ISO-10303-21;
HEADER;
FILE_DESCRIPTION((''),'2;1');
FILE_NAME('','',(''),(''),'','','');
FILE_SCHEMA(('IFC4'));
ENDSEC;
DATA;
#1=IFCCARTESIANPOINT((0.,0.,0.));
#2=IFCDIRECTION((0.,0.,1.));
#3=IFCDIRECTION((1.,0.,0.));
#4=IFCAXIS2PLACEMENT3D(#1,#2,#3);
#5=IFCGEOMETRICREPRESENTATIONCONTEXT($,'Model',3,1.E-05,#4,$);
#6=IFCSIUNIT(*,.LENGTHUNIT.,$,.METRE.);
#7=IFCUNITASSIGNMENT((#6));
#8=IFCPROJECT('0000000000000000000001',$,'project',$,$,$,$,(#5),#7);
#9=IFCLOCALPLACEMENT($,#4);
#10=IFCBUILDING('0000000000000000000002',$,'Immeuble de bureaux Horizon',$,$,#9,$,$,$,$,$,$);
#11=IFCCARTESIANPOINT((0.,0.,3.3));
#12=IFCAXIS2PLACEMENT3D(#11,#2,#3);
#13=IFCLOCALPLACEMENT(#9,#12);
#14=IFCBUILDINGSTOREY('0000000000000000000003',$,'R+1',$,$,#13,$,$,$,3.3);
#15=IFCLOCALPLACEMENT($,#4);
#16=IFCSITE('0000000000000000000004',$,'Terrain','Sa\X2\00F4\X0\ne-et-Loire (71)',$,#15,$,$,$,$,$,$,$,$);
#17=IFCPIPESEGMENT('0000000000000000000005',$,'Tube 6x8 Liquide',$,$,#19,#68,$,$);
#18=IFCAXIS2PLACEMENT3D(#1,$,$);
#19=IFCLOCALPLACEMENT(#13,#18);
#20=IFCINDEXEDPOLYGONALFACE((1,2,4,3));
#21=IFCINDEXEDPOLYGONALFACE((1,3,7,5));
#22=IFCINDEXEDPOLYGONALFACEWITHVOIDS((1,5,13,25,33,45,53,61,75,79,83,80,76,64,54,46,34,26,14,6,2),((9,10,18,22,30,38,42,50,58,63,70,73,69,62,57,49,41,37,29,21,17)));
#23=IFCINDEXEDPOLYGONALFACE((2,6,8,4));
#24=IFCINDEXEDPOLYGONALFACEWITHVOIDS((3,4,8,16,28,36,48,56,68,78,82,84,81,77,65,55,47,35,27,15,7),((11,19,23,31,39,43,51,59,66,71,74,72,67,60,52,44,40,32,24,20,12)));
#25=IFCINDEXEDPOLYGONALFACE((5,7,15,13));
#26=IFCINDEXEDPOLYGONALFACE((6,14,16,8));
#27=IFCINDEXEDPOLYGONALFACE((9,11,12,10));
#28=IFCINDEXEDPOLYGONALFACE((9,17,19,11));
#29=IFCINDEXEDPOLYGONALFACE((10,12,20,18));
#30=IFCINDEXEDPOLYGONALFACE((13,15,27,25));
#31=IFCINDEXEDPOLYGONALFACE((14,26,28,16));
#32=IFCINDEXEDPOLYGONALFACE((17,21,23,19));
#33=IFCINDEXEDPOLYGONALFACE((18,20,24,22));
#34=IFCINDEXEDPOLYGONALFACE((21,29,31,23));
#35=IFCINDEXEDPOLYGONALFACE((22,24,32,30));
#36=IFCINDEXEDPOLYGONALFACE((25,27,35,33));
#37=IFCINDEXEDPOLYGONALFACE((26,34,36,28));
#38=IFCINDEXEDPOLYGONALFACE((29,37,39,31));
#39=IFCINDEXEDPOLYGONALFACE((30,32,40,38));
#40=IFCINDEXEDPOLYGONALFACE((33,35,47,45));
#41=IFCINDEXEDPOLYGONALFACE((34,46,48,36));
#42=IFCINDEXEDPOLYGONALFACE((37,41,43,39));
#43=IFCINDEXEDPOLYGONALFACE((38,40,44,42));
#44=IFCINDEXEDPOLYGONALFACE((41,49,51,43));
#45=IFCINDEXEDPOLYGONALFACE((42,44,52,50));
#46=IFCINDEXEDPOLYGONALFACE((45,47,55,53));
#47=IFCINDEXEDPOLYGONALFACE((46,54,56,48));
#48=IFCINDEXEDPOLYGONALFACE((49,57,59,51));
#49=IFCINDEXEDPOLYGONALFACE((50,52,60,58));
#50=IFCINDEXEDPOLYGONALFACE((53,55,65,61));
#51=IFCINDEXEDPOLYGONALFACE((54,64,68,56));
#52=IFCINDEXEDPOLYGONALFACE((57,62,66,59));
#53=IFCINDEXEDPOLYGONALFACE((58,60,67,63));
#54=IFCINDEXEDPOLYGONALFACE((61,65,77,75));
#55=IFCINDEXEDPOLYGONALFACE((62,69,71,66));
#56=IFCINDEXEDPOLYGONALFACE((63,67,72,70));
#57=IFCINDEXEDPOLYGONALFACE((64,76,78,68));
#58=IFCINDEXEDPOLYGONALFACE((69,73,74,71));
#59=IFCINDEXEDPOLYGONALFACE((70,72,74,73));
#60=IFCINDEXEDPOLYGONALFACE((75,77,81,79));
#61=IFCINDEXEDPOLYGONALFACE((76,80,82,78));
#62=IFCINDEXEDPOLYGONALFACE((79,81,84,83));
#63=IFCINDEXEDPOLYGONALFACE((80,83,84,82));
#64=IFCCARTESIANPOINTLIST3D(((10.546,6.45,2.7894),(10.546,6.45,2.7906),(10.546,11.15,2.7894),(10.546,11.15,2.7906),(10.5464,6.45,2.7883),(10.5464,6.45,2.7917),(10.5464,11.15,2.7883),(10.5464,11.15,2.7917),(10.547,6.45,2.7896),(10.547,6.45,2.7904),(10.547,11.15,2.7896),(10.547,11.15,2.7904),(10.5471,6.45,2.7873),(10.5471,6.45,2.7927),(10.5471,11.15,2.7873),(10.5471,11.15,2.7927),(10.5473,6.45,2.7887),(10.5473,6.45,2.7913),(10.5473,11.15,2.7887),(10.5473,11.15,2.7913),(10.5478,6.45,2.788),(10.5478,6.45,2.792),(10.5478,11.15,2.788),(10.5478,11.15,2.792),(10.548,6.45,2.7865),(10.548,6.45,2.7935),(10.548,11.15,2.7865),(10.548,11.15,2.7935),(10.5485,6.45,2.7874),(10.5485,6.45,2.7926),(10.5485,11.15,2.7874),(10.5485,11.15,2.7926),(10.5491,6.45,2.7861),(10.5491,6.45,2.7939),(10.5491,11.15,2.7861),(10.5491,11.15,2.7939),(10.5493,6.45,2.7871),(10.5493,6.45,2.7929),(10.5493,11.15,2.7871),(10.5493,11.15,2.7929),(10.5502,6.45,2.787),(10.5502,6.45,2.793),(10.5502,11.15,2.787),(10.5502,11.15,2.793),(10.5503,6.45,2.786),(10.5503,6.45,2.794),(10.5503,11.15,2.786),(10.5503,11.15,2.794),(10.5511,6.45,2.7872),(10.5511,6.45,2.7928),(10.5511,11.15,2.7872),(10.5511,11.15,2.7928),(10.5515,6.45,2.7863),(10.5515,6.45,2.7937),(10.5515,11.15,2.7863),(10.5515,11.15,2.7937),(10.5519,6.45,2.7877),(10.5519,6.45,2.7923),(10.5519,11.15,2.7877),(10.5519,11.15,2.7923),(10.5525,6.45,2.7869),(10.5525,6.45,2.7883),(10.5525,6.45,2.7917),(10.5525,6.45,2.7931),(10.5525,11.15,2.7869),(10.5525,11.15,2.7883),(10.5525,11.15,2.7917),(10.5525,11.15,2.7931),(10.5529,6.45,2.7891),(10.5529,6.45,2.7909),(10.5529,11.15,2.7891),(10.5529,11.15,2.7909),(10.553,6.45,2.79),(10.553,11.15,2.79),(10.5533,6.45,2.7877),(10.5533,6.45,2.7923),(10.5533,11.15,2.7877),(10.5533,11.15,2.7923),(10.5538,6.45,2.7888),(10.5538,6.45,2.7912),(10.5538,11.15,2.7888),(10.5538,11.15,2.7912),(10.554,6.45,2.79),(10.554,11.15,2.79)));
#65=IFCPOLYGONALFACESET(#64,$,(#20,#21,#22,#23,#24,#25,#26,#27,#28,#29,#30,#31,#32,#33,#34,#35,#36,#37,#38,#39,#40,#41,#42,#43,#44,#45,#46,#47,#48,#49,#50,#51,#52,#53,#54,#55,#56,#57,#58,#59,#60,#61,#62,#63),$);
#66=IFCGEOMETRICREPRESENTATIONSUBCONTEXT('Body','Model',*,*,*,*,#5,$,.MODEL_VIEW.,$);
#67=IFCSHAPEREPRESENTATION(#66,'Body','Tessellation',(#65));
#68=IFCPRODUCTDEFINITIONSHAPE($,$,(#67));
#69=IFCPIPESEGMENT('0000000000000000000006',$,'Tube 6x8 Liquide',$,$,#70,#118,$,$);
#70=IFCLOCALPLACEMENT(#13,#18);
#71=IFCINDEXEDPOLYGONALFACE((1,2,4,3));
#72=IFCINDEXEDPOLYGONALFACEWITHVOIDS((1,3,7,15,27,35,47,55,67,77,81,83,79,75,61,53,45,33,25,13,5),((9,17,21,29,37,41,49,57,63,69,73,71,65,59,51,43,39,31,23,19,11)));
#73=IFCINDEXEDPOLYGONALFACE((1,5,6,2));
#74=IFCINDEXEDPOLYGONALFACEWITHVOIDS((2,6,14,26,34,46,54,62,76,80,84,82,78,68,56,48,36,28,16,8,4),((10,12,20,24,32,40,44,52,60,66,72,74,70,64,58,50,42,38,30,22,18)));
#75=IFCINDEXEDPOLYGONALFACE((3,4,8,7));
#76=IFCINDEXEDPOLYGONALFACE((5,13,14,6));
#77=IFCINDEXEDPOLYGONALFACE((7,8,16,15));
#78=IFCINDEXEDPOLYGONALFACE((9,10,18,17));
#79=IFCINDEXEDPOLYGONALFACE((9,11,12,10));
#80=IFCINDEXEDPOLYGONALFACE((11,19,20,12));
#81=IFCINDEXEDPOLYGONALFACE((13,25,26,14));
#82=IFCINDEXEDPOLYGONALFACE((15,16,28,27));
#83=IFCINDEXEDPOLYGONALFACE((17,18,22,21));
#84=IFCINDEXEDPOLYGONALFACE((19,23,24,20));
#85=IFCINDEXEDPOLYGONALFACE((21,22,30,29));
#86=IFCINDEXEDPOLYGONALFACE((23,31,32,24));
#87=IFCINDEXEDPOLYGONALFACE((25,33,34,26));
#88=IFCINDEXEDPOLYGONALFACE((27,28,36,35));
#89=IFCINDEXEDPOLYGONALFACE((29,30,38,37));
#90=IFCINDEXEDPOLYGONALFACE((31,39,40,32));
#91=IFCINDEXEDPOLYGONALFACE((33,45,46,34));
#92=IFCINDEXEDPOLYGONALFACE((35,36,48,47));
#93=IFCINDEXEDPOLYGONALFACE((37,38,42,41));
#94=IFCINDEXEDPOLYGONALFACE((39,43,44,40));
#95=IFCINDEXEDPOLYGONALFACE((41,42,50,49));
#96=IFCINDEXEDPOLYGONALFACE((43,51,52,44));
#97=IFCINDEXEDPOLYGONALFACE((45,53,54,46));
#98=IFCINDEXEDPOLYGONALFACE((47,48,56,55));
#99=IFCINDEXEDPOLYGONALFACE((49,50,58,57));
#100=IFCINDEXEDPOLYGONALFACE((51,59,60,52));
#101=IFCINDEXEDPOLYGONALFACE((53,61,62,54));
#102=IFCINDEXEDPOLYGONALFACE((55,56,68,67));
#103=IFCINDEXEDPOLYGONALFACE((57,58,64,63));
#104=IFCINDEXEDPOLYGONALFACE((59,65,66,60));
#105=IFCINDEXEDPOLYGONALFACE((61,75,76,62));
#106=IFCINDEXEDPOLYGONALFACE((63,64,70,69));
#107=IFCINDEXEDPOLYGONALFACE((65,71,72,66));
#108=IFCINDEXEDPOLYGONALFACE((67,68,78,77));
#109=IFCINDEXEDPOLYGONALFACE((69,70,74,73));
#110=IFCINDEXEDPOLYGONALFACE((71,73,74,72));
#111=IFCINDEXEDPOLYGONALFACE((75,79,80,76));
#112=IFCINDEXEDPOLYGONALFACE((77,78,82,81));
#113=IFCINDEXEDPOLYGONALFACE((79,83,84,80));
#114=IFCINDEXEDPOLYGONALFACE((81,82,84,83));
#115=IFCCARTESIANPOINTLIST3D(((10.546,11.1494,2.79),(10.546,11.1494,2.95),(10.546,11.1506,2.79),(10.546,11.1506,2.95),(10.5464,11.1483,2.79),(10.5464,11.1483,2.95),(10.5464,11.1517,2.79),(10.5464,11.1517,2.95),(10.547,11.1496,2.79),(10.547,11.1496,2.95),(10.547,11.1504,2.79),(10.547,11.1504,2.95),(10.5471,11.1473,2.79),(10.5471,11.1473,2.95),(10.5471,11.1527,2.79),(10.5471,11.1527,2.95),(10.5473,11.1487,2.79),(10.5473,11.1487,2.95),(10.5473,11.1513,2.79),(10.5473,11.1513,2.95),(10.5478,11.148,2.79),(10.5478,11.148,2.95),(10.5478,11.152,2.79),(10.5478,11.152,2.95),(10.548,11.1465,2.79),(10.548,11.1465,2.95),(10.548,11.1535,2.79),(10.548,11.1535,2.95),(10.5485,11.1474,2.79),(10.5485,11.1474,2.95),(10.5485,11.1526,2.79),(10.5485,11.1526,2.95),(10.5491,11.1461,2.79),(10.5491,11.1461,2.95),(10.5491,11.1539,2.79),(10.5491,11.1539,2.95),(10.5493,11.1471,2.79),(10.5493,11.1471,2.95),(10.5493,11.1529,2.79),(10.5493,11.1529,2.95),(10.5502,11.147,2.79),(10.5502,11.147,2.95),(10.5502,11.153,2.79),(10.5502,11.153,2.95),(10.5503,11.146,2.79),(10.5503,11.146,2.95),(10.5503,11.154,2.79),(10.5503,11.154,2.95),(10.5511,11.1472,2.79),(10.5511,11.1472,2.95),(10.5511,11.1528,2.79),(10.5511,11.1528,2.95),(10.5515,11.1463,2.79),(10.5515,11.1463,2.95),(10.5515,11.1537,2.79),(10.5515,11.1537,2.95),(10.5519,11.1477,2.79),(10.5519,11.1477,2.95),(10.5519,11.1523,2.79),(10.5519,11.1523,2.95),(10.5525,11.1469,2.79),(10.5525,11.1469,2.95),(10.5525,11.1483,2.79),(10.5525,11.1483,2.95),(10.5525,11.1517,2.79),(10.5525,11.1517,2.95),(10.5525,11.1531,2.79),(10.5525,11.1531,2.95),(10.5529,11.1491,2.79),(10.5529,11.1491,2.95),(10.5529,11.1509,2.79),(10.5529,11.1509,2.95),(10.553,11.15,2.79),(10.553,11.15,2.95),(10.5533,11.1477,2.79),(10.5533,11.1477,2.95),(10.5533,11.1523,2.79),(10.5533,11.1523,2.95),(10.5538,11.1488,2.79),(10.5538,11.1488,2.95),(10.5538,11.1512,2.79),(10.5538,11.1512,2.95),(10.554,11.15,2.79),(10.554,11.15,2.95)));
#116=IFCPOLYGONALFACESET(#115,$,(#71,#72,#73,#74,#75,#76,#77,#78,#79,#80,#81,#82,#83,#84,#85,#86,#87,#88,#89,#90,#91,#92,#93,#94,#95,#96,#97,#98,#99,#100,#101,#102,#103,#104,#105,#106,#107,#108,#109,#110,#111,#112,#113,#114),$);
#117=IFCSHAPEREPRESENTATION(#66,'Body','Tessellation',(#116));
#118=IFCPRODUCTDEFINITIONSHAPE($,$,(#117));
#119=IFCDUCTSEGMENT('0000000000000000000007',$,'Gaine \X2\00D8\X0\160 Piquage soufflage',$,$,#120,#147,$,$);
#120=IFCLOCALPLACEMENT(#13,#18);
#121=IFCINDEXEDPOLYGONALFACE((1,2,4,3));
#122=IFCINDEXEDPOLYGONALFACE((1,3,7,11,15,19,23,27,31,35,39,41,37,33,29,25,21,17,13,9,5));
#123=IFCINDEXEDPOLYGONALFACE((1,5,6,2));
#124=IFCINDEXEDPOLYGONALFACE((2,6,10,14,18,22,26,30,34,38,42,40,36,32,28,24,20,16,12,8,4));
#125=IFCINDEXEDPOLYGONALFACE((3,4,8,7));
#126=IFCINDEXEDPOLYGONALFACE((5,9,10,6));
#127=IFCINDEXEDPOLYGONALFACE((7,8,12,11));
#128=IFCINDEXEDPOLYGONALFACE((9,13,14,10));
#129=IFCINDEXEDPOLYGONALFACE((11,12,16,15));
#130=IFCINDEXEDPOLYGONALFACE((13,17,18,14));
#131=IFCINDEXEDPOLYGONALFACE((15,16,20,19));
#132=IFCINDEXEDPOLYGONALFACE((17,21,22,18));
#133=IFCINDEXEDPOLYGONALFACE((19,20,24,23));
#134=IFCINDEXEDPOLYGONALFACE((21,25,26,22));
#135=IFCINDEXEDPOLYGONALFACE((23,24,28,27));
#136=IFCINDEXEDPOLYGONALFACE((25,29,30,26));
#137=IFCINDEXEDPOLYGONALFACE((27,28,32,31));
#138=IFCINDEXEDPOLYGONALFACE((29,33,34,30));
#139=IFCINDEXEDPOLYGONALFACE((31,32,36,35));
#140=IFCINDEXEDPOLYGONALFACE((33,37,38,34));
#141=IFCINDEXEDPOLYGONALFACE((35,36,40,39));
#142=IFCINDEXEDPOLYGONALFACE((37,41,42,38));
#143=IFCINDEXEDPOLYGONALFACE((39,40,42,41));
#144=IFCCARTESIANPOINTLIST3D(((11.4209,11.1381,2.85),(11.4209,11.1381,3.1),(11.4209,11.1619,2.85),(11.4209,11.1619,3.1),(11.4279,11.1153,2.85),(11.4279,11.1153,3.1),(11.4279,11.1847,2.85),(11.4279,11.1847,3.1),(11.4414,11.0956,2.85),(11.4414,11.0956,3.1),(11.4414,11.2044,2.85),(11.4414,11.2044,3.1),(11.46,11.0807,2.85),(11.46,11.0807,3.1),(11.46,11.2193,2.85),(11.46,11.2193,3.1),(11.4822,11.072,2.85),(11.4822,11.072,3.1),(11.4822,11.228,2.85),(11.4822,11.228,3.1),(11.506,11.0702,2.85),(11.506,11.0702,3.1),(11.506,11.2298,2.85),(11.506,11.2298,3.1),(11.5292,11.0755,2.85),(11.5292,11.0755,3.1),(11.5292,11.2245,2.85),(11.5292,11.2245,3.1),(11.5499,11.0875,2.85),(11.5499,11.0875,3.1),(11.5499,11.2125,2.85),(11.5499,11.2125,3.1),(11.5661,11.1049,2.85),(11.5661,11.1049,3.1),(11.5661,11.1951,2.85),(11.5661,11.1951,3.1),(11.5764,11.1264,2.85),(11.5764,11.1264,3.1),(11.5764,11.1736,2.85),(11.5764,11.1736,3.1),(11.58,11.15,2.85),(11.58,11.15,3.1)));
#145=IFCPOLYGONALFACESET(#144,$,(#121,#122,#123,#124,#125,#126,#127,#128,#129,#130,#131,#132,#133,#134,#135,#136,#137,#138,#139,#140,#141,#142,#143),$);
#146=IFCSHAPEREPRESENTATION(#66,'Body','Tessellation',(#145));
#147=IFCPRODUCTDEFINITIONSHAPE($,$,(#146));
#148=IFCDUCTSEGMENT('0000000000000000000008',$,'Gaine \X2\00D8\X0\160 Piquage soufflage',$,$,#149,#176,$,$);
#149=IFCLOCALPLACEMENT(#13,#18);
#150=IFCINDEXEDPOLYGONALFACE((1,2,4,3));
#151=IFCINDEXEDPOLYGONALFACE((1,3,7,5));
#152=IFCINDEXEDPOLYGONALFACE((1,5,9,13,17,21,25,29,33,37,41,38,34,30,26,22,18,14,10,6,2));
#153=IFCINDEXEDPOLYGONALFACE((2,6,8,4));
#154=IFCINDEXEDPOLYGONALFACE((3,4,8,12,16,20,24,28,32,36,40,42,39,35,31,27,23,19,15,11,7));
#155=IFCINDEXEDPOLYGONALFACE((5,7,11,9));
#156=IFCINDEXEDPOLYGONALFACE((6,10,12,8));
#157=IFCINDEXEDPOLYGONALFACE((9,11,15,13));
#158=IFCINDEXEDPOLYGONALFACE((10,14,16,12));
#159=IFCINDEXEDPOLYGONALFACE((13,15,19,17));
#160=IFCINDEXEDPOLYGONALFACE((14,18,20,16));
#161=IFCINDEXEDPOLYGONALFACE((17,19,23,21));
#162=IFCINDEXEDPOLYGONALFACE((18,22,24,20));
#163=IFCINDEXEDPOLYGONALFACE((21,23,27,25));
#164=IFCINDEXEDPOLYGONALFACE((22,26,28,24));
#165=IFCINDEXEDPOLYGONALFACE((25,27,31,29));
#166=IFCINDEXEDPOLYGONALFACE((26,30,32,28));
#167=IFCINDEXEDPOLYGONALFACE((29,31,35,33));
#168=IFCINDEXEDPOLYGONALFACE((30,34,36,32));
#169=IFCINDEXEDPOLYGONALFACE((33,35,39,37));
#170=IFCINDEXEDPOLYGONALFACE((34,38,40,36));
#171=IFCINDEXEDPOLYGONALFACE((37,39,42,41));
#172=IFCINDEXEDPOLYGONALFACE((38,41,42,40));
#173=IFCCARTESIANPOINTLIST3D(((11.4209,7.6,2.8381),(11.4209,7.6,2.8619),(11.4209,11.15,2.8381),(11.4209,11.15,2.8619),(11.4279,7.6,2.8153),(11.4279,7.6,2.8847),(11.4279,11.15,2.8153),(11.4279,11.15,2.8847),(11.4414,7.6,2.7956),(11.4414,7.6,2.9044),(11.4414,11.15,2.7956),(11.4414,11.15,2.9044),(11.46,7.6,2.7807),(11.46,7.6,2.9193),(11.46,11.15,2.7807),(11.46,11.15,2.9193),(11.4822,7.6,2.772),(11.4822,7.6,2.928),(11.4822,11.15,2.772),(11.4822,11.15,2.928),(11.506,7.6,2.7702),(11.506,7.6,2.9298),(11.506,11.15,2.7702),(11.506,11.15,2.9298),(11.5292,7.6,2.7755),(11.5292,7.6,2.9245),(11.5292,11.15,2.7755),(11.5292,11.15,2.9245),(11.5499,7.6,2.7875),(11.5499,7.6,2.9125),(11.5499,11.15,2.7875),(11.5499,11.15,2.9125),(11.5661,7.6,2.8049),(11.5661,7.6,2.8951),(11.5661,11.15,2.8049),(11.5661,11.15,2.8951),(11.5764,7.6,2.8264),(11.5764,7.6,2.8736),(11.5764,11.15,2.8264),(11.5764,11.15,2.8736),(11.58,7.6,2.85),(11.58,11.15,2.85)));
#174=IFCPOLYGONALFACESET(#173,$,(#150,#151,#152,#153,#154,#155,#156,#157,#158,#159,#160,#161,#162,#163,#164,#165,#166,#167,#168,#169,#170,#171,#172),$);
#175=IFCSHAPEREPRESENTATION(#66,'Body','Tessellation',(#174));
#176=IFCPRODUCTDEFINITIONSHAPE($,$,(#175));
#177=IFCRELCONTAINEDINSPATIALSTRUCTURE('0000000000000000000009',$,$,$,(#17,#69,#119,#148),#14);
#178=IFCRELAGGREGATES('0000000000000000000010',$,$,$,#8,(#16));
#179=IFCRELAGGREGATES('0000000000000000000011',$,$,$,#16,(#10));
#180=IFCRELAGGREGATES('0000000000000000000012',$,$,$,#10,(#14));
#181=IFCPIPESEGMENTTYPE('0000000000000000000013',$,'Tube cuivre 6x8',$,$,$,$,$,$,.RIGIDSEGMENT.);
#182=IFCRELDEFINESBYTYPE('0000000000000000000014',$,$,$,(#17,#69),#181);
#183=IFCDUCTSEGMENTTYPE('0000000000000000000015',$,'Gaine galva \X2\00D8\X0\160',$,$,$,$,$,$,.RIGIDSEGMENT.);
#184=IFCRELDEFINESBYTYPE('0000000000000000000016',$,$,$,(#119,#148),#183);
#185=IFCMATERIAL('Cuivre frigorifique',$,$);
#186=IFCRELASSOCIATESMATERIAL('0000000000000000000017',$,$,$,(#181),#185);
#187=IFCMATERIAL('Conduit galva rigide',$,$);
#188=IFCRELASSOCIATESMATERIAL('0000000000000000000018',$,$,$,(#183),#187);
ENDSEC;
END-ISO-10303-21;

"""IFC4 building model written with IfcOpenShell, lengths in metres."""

from ifc_helpers import new_model, si_unit, frame, origin_with_axes, place, context, subcontext, project, spatial, circle, hollow_circle, extrude, material, type_object, element, save


model = new_model("IFC4")

# Units and contexts
model_context = context("Model", 3, precision=1e-05, world=origin_with_axes())
body_context = subcontext(model_context, "Body", "Model", "MODEL_VIEW")
ifc_project = project(units=[si_unit("LENGTHUNIT", "METRE")], contexts=[model_context])

# Site, building, storey
site_placement = place(None, origin_with_axes())
site = spatial("IfcSite", under=ifc_project, at=site_placement, Name="Terrain", Description="Saône-et-Loire (71)")
building_placement = place(None, origin_with_axes())
building = spatial("IfcBuilding", under=site, at=building_placement, Name="Immeuble de bureaux Horizon")
storey_placement = place(building_placement, frame((0.0, 0.0, 3.3), z_axis=(0.0, 0.0, 1.0), x_axis=(1.0, 0.0, 0.0)))
storey = spatial("IfcBuildingStorey", under=building, at=storey_placement, Name="R+1", Elevation=3.3)

# Pipe segments
ifc_material_1 = material(Name="Cuivre frigorifique")
pipe_segment_type_1 = type_object("IfcPipeSegmentType", Name="Tube cuivre 6x8", PredefinedType="RIGIDSEGMENT", material=ifc_material_1)
pipe_segment_1_placement = place(storey_placement, frame((10.55, 6.45, 2.79), z_axis=(0.0, 1.0, 0.0), x_axis=(1.0, 0.0, 0.0)))
element("IfcPipeSegment", 1, at=pipe_segment_1_placement, inside=storey, type_object=pipe_segment_type_1, Name="Tube 6x8 Liquide", context=body_context, shape_type="SweptSolid", body=[
    extrude(hollow_circle(Radius=0.004, WallThickness=0.001), origin_with_axes(), (0.0, 0.0, 1.0), 4.7),
])
pipe_segment_2_placement = place(storey_placement, frame((10.55, 11.15, 2.79), z_axis=(0.0, 0.0, 1.0), x_axis=(1.0, 0.0, 0.0)))
element("IfcPipeSegment", 2, at=pipe_segment_2_placement, inside=storey, type_object=pipe_segment_type_1, Name="Tube 6x8 Liquide", context=body_context, shape_type="SweptSolid", body=[
    extrude(hollow_circle(Radius=0.004, WallThickness=0.001), origin_with_axes(), (0.0, 0.0, 1.0), 0.16),
])

# Duct segments
ifc_material_2 = material(Name="Conduit galva rigide")
duct_segment_type = type_object("IfcDuctSegmentType", Name="Gaine galva Ø160", PredefinedType="RIGIDSEGMENT", material=ifc_material_2)
duct_segment_1_placement = place(storey_placement, frame((11.5, 11.15, 3.1), z_axis=(0.0, 0.0, -1.0), x_axis=(1.0, 0.0, 0.0)))
element("IfcDuctSegment", 3, at=duct_segment_1_placement, inside=storey, type_object=duct_segment_type, Name="Gaine Ø160 Piquage soufflage", context=body_context, shape_type="SweptSolid", body=[
    extrude(circle(Radius=0.08), origin_with_axes(), (0.0, 0.0, 1.0), 0.25),
])
duct_segment_2_placement = place(storey_placement, frame((11.5, 11.15, 2.85), z_axis=(0.0, -1.0, 0.0), x_axis=(1.0, 0.0, 0.0)))
element("IfcDuctSegment", 4, at=duct_segment_2_placement, inside=storey, type_object=duct_segment_type, Name="Gaine Ø160 Piquage soufflage", context=body_context, shape_type="SweptSolid", body=[
    extrude(circle(Radius=0.08), origin_with_axes(), (0.0, 0.0, 1.0), 3.55),
])

save(model, "model.ifc")
